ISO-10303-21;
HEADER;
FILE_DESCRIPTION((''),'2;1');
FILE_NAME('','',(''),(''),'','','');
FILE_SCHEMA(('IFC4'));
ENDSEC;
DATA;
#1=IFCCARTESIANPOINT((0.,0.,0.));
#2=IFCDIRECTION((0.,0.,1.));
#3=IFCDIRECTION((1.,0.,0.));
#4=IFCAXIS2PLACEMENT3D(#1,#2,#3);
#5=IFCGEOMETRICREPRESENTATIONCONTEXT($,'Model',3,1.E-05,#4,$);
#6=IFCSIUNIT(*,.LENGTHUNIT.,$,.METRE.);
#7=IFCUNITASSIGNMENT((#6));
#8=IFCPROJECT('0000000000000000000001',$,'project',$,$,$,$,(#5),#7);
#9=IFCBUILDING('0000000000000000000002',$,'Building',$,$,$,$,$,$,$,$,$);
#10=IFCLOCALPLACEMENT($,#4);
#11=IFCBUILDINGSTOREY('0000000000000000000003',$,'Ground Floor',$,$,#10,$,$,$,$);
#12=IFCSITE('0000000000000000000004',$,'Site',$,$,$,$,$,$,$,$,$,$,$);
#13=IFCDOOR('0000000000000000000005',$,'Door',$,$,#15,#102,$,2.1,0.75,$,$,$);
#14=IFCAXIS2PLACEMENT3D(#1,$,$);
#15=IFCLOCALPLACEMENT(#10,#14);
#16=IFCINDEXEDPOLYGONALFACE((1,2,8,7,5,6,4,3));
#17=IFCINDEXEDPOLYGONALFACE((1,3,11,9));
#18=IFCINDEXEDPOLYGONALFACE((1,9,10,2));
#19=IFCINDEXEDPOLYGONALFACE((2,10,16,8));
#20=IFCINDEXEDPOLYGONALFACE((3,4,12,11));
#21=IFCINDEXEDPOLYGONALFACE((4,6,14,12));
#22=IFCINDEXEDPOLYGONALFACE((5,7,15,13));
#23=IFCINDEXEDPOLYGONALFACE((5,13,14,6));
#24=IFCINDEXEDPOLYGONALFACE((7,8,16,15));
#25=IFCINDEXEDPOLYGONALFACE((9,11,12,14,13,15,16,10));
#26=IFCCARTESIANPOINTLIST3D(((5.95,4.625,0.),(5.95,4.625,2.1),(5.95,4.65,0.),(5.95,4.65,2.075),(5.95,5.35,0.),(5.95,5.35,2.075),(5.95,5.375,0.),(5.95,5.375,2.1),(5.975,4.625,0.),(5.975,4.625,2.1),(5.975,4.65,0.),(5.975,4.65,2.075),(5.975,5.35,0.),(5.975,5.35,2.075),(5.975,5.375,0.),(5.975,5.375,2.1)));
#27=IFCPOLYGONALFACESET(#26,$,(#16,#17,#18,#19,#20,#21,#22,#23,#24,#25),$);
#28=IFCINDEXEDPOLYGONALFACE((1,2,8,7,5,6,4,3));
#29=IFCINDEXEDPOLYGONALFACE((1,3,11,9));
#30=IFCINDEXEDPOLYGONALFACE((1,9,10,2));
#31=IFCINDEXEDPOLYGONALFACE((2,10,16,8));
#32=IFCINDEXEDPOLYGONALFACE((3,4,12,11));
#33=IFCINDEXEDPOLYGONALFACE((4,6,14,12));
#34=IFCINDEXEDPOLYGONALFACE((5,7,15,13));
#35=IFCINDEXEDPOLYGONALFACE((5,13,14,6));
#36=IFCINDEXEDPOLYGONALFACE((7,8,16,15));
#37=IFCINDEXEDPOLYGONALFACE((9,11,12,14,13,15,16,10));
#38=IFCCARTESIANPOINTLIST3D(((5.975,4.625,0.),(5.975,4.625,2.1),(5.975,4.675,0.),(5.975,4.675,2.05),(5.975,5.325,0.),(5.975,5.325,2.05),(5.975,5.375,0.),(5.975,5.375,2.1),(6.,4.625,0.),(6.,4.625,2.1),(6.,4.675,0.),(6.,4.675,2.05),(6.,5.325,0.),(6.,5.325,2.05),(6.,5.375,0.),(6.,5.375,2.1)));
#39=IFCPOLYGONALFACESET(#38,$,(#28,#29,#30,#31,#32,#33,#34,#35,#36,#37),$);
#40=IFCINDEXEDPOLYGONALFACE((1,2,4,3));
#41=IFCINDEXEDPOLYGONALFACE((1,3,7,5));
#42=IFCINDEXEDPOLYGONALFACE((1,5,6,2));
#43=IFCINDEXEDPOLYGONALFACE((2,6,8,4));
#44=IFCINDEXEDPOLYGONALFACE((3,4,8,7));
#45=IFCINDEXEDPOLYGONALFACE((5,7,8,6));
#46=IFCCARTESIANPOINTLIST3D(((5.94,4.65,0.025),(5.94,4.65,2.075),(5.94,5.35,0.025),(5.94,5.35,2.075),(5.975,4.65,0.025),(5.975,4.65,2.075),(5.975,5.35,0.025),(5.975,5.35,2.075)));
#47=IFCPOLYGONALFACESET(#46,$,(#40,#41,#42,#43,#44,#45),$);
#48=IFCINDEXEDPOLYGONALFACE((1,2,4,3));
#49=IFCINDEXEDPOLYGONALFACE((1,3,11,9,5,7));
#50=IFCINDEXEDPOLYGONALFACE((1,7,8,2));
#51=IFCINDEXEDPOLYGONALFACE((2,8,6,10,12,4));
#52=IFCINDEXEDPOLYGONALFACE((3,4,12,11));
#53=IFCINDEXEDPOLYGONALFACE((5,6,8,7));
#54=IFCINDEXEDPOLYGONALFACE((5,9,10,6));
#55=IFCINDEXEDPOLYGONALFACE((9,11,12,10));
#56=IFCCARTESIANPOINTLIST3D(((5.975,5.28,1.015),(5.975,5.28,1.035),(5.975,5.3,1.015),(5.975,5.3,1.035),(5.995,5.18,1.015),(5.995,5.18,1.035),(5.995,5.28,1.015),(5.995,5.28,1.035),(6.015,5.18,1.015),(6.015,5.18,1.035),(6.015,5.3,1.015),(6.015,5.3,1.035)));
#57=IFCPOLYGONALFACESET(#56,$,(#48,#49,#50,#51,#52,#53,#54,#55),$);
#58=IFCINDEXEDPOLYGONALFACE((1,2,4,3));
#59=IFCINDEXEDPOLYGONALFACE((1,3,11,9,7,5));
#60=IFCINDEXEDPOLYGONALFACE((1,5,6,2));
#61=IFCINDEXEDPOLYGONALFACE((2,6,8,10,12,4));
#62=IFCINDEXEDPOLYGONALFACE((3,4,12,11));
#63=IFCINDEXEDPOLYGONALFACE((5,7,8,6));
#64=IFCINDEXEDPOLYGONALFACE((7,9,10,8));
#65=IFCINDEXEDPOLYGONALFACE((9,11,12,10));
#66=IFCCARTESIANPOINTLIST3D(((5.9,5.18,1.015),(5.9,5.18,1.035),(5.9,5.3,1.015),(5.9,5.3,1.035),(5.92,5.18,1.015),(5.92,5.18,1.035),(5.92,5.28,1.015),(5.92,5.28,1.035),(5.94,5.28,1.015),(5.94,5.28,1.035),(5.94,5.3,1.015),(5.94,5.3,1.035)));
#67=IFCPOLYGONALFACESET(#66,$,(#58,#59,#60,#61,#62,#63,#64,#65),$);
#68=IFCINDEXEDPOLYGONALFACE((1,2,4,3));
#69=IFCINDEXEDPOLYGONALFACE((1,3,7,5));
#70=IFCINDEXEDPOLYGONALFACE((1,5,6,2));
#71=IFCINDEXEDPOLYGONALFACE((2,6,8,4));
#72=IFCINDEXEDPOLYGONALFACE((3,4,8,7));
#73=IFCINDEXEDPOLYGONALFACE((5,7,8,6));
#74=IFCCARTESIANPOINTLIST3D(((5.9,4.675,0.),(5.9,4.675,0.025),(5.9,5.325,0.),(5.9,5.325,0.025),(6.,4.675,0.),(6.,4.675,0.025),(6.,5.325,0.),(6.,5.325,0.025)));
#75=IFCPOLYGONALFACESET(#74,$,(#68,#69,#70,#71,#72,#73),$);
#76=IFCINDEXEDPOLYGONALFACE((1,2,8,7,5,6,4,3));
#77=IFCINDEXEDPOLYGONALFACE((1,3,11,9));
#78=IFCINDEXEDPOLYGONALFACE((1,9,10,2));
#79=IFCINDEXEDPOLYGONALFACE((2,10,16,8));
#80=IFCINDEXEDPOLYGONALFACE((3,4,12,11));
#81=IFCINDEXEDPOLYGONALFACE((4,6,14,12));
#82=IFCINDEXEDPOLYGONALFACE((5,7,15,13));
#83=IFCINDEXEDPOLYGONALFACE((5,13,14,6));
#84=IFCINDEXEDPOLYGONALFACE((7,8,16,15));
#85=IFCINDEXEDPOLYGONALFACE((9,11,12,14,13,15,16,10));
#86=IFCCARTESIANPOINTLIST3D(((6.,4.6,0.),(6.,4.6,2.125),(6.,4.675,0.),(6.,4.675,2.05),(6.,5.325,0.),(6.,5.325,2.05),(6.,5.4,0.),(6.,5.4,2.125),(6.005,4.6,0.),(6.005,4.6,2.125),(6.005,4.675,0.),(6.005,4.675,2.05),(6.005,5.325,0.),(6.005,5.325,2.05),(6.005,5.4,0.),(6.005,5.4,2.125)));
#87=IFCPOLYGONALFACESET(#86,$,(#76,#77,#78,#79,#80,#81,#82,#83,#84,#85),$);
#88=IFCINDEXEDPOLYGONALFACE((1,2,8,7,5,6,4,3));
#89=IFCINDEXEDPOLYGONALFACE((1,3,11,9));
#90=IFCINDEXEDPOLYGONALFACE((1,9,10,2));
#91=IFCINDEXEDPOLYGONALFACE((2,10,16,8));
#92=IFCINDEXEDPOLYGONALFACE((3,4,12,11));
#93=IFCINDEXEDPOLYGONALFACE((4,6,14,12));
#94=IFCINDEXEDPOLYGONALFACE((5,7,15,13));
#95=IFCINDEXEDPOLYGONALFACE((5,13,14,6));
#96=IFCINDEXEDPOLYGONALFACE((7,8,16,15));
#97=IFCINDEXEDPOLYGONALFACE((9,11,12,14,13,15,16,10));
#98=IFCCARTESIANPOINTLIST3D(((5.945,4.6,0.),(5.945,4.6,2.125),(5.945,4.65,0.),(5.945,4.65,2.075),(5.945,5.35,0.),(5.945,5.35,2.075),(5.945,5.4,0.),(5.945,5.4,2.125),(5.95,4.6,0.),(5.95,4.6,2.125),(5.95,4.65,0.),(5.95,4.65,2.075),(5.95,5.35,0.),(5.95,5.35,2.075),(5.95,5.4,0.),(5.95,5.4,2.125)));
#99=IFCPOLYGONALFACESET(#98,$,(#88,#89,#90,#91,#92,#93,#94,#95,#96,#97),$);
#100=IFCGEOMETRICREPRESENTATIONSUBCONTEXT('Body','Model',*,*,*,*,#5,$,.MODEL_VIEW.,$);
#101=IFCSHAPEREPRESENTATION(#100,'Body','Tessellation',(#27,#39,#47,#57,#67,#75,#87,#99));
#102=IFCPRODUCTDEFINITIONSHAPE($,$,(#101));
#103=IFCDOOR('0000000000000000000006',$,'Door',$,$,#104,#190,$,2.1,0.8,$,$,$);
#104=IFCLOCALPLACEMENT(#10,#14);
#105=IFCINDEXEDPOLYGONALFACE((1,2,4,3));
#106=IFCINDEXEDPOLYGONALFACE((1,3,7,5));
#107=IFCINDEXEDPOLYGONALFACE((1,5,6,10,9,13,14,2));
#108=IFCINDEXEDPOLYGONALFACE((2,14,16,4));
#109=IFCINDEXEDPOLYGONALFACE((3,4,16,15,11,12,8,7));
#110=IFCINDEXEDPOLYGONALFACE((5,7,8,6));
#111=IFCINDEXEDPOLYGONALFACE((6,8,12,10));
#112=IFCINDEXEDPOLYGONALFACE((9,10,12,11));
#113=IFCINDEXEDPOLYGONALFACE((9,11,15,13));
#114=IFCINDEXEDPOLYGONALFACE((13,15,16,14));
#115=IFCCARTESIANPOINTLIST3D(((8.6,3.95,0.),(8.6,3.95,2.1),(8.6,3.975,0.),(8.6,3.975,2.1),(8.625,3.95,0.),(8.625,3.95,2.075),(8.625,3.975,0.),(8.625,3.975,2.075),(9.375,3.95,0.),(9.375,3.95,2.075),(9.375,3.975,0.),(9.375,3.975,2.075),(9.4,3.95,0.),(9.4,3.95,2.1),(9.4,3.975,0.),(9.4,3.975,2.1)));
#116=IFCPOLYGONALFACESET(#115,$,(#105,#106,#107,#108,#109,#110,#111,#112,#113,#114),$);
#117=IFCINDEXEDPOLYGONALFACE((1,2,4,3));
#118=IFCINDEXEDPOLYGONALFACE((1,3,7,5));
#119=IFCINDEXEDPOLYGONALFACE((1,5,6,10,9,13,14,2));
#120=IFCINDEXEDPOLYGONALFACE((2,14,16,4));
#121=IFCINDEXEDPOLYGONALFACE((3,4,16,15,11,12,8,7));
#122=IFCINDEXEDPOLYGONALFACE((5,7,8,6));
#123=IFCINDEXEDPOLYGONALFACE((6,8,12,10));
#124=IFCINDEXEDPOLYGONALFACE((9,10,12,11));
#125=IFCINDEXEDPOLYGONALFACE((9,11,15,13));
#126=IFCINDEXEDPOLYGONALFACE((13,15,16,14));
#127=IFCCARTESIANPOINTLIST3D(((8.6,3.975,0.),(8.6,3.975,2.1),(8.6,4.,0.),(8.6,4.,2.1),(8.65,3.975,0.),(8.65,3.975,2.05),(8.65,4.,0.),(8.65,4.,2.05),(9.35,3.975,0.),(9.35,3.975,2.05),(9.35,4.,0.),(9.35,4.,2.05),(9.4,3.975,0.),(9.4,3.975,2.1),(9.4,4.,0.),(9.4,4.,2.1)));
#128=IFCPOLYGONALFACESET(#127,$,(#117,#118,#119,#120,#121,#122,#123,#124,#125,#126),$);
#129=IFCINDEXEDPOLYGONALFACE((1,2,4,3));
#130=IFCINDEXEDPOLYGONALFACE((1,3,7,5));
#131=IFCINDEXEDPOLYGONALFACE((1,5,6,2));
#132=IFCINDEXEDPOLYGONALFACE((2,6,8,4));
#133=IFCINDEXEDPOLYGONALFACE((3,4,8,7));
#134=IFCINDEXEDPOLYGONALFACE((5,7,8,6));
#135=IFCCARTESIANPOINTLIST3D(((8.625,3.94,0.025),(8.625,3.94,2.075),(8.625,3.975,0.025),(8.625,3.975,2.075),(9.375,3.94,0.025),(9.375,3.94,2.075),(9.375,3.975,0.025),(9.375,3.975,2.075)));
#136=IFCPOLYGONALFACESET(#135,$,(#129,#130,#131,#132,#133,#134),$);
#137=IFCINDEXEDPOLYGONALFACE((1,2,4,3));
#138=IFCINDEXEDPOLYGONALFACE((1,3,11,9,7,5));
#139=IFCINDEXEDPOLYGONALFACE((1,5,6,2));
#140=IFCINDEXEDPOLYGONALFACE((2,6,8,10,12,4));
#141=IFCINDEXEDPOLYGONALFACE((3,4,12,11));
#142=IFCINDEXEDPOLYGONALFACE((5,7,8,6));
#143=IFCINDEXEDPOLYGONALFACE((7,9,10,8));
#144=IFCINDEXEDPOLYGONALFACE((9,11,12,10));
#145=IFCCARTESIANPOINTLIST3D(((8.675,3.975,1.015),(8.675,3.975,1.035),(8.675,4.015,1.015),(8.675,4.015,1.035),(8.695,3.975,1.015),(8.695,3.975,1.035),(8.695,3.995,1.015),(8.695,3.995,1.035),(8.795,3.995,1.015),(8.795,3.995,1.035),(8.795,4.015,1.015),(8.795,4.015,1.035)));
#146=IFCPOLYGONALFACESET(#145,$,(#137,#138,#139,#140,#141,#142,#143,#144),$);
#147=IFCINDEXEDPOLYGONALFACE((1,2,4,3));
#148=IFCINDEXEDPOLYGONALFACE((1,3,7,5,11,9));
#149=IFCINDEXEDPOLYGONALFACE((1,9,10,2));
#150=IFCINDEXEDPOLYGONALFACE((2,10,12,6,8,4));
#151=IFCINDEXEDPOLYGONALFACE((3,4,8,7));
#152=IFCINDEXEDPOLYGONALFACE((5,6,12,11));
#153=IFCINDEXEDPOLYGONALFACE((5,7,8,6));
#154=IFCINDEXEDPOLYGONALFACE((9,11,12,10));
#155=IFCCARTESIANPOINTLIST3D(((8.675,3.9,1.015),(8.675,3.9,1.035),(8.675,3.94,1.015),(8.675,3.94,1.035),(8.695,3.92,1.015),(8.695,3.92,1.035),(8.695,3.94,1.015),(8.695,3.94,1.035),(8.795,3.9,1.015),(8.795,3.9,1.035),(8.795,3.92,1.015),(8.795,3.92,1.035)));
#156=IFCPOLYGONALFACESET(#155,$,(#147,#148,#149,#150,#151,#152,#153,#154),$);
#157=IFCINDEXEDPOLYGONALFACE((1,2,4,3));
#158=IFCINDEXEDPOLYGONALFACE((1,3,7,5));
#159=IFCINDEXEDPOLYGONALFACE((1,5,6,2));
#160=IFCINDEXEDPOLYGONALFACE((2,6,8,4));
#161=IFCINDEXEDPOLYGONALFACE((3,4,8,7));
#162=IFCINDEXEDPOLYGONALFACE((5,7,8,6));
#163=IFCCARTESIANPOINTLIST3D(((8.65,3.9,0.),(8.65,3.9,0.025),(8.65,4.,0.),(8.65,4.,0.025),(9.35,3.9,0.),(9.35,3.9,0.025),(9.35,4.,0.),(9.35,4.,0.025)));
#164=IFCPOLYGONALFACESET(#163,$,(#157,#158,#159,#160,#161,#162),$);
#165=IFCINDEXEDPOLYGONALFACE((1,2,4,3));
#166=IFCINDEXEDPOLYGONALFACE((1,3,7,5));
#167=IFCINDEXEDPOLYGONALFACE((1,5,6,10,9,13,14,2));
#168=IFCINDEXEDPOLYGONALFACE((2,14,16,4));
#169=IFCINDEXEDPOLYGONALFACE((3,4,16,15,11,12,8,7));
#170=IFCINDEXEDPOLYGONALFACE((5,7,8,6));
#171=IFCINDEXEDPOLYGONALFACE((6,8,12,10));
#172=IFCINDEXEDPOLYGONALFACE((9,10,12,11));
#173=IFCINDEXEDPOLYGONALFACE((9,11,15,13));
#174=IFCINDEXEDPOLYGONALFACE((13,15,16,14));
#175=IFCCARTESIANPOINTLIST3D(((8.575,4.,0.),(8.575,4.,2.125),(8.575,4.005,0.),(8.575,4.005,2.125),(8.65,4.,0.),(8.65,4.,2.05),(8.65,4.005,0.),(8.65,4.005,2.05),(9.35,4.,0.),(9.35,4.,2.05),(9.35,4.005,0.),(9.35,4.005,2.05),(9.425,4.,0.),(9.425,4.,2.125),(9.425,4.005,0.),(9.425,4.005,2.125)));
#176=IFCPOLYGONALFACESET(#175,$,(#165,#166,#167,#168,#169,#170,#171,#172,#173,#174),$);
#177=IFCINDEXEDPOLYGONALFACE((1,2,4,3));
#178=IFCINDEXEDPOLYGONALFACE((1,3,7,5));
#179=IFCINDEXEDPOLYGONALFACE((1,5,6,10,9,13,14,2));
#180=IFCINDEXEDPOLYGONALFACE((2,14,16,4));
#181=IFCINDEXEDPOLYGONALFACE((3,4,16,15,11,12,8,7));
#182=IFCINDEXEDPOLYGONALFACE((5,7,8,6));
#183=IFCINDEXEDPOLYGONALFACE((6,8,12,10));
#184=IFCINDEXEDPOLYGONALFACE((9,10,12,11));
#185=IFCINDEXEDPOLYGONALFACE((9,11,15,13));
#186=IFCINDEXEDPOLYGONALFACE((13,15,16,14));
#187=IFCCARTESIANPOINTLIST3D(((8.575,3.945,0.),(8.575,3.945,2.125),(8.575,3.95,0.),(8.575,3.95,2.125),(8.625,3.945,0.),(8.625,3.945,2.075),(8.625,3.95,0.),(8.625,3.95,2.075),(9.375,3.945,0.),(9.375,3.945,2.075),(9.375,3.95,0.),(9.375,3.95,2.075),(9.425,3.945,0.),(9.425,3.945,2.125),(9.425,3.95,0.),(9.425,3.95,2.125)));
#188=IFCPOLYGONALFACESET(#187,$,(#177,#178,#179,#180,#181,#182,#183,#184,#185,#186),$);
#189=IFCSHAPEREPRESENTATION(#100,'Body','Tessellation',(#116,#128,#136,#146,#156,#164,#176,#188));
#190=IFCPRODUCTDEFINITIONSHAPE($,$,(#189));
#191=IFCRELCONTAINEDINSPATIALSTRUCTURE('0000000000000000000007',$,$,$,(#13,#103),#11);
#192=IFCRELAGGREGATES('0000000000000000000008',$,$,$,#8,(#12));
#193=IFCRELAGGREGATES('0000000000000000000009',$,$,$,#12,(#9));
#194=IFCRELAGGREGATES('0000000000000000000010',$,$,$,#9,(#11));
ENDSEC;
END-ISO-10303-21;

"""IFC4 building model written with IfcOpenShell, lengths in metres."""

from ifc_helpers import new_model, si_unit, frame, origin_with_axes, place, context, subcontext, project, spatial, line, indexed_curve, outline, extrude, element, save


model = new_model("IFC4")

# Units and contexts
model_context = context("Model", 3, precision=1e-05, world=origin_with_axes())
body_context = subcontext(model_context, "Body", "Model", "MODEL_VIEW")
ifc_project = project(units=[si_unit("LENGTHUNIT", "METRE")], contexts=[model_context])

# Site, building, storey
site = spatial("IfcSite", under=ifc_project, Name="Site")
building = spatial("IfcBuilding", under=site, Name="Building")
storey_placement = place(None, origin_with_axes())
storey = spatial("IfcBuildingStorey", under=building, at=storey_placement, Name="Ground Floor")

# Doors
door_1_placement = place(storey_placement, frame((6.0, 4.625, 0.0), z_axis=(0.0, 0.0, 1.0), x_axis=(0.0, 1.0, 0.0)))
element("IfcDoor", 1, at=door_1_placement, inside=storey, Name="Door", OverallHeight=2.1, OverallWidth=0.75, context=body_context, shape_type="SweptSolid", body=[
    extrude(outline(indexed_curve([(0.0, 0.0), (0.0, 2.1), (0.75, 2.1), (0.75, 0.0), (0.725, 0.0), (0.725, 2.075), (0.025, 2.075), (0.025, 0.0)], segments=[line(1, 2, 3, 4, 5, 6, 7, 8, 1)])), frame((0.0, 0.025, 0.0), z_axis=(0.0, -1.0, 0.0), x_axis=(1.0, 0.0, 0.0)), (0.0, 0.0, -1.0), 0.025),
    extrude(outline(indexed_curve([(0.0, 0.0), (0.0, 2.1), (0.75, 2.1), (0.75, 0.0), (0.7, 0.0), (0.7, 2.05), (0.05, 2.05), (0.05, 0.0)], segments=[line(1, 2, 3, 4, 5, 6, 7, 8, 1)])), frame((0.0, 0.0, 0.0), z_axis=(0.0, -1.0, 0.0), x_axis=(1.0, 0.0, 0.0)), (0.0, 0.0, -1.0), 0.025),
    extrude(outline(indexed_curve([(0.0, 0.0), (0.7, 0.0), (0.7, 0.035), (0.0, 0.035)], segments=[line(1, 2, 3, 4, 1)])), frame((0.025, 0.025, 0.025), z_axis=(0.0, 0.0, 1.0), x_axis=(1.0, 0.0, 0.0)), (0.0, 0.0, 1.0), 2.05),
    extrude(outline(indexed_curve([(0.0, 0.0), (0.0, -0.04), (-0.12, -0.04), (-0.12, -0.02), (-0.02, -0.02), (-0.02, 0.0)], segments=[line(1, 2, 3, 4, 5, 6, 1)])), frame((0.675, 0.025, 1.015), z_axis=(0.0, 0.0, 1.0), x_axis=(1.0, 0.0, 0.0)), (0.0, 0.0, 1.0), 0.02),
    extrude(outline(indexed_curve([(0.0, 0.0), (0.0, 0.04), (-0.12, 0.04), (-0.12, 0.02), (-0.02, 0.02), (-0.02, 0.0)], segments=[line(1, 2, 3, 4, 5, 6, 1)])), frame((0.675, 0.06, 1.015), z_axis=(0.0, 0.0, 1.0), x_axis=(1.0, 0.0, 0.0)), (0.0, 0.0, 1.0), 0.02),
    extrude(outline(indexed_curve([(0.0, 0.0), (0.65, 0.0), (0.65, 0.1), (0.0, 0.1)], segments=[line(1, 2, 3, 4, 1)])), frame((0.05, 0.0, 0.0), z_axis=(0.0, 0.0, 1.0), x_axis=(1.0, 0.0, 0.0)), (0.0, 0.0, 1.0), 0.025),
    extrude(outline(indexed_curve([(0.0, 0.0), (0.0, 2.125), (0.8, 2.125), (0.8, 0.0), (0.725, 0.0), (0.725, 2.05), (0.075, 2.05), (0.075, 0.0)], segments=[line(1, 2, 3, 4, 5, 6, 7, 8, 1)])), frame((-0.025, -0.005, 0.0), z_axis=(0.0, -1.0, 0.0), x_axis=(1.0, 0.0, 0.0)), (0.0, 0.0, -1.0), 0.005),
    extrude(outline(indexed_curve([(0.0, 0.0), (0.0, 2.125), (0.8, 2.125), (0.8, 0.0), (0.75, 0.0), (0.75, 2.075), (0.05, 2.075), (0.05, 0.0)], segments=[line(1, 2, 3, 4, 5, 6, 7, 8, 1)])), frame((-0.025, 0.05, 0.0), z_axis=(0.0, -1.0, 0.0), x_axis=(1.0, 0.0, 0.0)), (0.0, 0.0, -1.0), 0.005),
])
door_2_placement = place(storey_placement, frame((9.4, 4.0, 0.0), z_axis=(0.0, 0.0, 1.0), x_axis=(-1.0, 0.0, 0.0)))
element("IfcDoor", 2, at=door_2_placement, inside=storey, Name="Door", OverallHeight=2.1, OverallWidth=0.8, context=body_context, shape_type="SweptSolid", body=[
    extrude(outline(indexed_curve([(0.0, 0.0), (0.0, 2.1), (0.8, 2.1), (0.8, 0.0), (0.775, 0.0), (0.775, 2.075), (0.025, 2.075), (0.025, 0.0)], segments=[line(1, 2, 3, 4, 5, 6, 7, 8, 1)])), frame((0.0, 0.025, 0.0), z_axis=(0.0, -1.0, 0.0), x_axis=(1.0, 0.0, 0.0)), (0.0, 0.0, -1.0), 0.025),
    extrude(outline(indexed_curve([(0.0, 0.0), (0.0, 2.1), (0.8, 2.1), (0.8, 0.0), (0.75, 0.0), (0.75, 2.05), (0.05, 2.05), (0.05, 0.0)], segments=[line(1, 2, 3, 4, 5, 6, 7, 8, 1)])), frame((0.0, 0.0, 0.0), z_axis=(0.0, -1.0, 0.0), x_axis=(1.0, 0.0, 0.0)), (0.0, 0.0, -1.0), 0.025),
    extrude(outline(indexed_curve([(0.0, 0.0), (0.75, 0.0), (0.75, 0.035), (0.0, 0.035)], segments=[line(1, 2, 3, 4, 1)])), frame((0.025, 0.025, 0.025), z_axis=(0.0, 0.0, 1.0), x_axis=(1.0, 0.0, 0.0)), (0.0, 0.0, 1.0), 2.05),
    extrude(outline(indexed_curve([(0.0, 0.0), (0.0, -0.04), (-0.12, -0.04), (-0.12, -0.02), (-0.02, -0.02), (-0.02, 0.0)], segments=[line(1, 2, 3, 4, 5, 6, 1)])), frame((0.725, 0.025, 1.015), z_axis=(0.0, 0.0, 1.0), x_axis=(1.0, 0.0, 0.0)), (0.0, 0.0, 1.0), 0.02),
    extrude(outline(indexed_curve([(0.0, 0.0), (0.0, 0.04), (-0.12, 0.04), (-0.12, 0.02), (-0.02, 0.02), (-0.02, 0.0)], segments=[line(1, 2, 3, 4, 5, 6, 1)])), frame((0.725, 0.06, 1.015), z_axis=(0.0, 0.0, 1.0), x_axis=(1.0, 0.0, 0.0)), (0.0, 0.0, 1.0), 0.02),
    extrude(outline(indexed_curve([(0.0, 0.0), (0.7, 0.0), (0.7, 0.1), (0.0, 0.1)], segments=[line(1, 2, 3, 4, 1)])), frame((0.05, 0.0, 0.0), z_axis=(0.0, 0.0, 1.0), x_axis=(1.0, 0.0, 0.0)), (0.0, 0.0, 1.0), 0.025),
    extrude(outline(indexed_curve([(0.0, 0.0), (0.0, 2.125), (0.85, 2.125), (0.85, 0.0), (0.775, 0.0), (0.775, 2.05), (0.075, 2.05), (0.075, 0.0)], segments=[line(1, 2, 3, 4, 5, 6, 7, 8, 1)])), frame((-0.025, -0.005, 0.0), z_axis=(0.0, -1.0, 0.0), x_axis=(1.0, 0.0, 0.0)), (0.0, 0.0, -1.0), 0.005),
    extrude(outline(indexed_curve([(0.0, 0.0), (0.0, 2.125), (0.85, 2.125), (0.85, 0.0), (0.8, 0.0), (0.8, 2.075), (0.05, 2.075), (0.05, 0.0)], segments=[line(1, 2, 3, 4, 5, 6, 7, 8, 1)])), frame((-0.025, 0.05, 0.0), z_axis=(0.0, -1.0, 0.0), x_axis=(1.0, 0.0, 0.0)), (0.0, 0.0, -1.0), 0.005),
])

save(model, "model.ifc")
